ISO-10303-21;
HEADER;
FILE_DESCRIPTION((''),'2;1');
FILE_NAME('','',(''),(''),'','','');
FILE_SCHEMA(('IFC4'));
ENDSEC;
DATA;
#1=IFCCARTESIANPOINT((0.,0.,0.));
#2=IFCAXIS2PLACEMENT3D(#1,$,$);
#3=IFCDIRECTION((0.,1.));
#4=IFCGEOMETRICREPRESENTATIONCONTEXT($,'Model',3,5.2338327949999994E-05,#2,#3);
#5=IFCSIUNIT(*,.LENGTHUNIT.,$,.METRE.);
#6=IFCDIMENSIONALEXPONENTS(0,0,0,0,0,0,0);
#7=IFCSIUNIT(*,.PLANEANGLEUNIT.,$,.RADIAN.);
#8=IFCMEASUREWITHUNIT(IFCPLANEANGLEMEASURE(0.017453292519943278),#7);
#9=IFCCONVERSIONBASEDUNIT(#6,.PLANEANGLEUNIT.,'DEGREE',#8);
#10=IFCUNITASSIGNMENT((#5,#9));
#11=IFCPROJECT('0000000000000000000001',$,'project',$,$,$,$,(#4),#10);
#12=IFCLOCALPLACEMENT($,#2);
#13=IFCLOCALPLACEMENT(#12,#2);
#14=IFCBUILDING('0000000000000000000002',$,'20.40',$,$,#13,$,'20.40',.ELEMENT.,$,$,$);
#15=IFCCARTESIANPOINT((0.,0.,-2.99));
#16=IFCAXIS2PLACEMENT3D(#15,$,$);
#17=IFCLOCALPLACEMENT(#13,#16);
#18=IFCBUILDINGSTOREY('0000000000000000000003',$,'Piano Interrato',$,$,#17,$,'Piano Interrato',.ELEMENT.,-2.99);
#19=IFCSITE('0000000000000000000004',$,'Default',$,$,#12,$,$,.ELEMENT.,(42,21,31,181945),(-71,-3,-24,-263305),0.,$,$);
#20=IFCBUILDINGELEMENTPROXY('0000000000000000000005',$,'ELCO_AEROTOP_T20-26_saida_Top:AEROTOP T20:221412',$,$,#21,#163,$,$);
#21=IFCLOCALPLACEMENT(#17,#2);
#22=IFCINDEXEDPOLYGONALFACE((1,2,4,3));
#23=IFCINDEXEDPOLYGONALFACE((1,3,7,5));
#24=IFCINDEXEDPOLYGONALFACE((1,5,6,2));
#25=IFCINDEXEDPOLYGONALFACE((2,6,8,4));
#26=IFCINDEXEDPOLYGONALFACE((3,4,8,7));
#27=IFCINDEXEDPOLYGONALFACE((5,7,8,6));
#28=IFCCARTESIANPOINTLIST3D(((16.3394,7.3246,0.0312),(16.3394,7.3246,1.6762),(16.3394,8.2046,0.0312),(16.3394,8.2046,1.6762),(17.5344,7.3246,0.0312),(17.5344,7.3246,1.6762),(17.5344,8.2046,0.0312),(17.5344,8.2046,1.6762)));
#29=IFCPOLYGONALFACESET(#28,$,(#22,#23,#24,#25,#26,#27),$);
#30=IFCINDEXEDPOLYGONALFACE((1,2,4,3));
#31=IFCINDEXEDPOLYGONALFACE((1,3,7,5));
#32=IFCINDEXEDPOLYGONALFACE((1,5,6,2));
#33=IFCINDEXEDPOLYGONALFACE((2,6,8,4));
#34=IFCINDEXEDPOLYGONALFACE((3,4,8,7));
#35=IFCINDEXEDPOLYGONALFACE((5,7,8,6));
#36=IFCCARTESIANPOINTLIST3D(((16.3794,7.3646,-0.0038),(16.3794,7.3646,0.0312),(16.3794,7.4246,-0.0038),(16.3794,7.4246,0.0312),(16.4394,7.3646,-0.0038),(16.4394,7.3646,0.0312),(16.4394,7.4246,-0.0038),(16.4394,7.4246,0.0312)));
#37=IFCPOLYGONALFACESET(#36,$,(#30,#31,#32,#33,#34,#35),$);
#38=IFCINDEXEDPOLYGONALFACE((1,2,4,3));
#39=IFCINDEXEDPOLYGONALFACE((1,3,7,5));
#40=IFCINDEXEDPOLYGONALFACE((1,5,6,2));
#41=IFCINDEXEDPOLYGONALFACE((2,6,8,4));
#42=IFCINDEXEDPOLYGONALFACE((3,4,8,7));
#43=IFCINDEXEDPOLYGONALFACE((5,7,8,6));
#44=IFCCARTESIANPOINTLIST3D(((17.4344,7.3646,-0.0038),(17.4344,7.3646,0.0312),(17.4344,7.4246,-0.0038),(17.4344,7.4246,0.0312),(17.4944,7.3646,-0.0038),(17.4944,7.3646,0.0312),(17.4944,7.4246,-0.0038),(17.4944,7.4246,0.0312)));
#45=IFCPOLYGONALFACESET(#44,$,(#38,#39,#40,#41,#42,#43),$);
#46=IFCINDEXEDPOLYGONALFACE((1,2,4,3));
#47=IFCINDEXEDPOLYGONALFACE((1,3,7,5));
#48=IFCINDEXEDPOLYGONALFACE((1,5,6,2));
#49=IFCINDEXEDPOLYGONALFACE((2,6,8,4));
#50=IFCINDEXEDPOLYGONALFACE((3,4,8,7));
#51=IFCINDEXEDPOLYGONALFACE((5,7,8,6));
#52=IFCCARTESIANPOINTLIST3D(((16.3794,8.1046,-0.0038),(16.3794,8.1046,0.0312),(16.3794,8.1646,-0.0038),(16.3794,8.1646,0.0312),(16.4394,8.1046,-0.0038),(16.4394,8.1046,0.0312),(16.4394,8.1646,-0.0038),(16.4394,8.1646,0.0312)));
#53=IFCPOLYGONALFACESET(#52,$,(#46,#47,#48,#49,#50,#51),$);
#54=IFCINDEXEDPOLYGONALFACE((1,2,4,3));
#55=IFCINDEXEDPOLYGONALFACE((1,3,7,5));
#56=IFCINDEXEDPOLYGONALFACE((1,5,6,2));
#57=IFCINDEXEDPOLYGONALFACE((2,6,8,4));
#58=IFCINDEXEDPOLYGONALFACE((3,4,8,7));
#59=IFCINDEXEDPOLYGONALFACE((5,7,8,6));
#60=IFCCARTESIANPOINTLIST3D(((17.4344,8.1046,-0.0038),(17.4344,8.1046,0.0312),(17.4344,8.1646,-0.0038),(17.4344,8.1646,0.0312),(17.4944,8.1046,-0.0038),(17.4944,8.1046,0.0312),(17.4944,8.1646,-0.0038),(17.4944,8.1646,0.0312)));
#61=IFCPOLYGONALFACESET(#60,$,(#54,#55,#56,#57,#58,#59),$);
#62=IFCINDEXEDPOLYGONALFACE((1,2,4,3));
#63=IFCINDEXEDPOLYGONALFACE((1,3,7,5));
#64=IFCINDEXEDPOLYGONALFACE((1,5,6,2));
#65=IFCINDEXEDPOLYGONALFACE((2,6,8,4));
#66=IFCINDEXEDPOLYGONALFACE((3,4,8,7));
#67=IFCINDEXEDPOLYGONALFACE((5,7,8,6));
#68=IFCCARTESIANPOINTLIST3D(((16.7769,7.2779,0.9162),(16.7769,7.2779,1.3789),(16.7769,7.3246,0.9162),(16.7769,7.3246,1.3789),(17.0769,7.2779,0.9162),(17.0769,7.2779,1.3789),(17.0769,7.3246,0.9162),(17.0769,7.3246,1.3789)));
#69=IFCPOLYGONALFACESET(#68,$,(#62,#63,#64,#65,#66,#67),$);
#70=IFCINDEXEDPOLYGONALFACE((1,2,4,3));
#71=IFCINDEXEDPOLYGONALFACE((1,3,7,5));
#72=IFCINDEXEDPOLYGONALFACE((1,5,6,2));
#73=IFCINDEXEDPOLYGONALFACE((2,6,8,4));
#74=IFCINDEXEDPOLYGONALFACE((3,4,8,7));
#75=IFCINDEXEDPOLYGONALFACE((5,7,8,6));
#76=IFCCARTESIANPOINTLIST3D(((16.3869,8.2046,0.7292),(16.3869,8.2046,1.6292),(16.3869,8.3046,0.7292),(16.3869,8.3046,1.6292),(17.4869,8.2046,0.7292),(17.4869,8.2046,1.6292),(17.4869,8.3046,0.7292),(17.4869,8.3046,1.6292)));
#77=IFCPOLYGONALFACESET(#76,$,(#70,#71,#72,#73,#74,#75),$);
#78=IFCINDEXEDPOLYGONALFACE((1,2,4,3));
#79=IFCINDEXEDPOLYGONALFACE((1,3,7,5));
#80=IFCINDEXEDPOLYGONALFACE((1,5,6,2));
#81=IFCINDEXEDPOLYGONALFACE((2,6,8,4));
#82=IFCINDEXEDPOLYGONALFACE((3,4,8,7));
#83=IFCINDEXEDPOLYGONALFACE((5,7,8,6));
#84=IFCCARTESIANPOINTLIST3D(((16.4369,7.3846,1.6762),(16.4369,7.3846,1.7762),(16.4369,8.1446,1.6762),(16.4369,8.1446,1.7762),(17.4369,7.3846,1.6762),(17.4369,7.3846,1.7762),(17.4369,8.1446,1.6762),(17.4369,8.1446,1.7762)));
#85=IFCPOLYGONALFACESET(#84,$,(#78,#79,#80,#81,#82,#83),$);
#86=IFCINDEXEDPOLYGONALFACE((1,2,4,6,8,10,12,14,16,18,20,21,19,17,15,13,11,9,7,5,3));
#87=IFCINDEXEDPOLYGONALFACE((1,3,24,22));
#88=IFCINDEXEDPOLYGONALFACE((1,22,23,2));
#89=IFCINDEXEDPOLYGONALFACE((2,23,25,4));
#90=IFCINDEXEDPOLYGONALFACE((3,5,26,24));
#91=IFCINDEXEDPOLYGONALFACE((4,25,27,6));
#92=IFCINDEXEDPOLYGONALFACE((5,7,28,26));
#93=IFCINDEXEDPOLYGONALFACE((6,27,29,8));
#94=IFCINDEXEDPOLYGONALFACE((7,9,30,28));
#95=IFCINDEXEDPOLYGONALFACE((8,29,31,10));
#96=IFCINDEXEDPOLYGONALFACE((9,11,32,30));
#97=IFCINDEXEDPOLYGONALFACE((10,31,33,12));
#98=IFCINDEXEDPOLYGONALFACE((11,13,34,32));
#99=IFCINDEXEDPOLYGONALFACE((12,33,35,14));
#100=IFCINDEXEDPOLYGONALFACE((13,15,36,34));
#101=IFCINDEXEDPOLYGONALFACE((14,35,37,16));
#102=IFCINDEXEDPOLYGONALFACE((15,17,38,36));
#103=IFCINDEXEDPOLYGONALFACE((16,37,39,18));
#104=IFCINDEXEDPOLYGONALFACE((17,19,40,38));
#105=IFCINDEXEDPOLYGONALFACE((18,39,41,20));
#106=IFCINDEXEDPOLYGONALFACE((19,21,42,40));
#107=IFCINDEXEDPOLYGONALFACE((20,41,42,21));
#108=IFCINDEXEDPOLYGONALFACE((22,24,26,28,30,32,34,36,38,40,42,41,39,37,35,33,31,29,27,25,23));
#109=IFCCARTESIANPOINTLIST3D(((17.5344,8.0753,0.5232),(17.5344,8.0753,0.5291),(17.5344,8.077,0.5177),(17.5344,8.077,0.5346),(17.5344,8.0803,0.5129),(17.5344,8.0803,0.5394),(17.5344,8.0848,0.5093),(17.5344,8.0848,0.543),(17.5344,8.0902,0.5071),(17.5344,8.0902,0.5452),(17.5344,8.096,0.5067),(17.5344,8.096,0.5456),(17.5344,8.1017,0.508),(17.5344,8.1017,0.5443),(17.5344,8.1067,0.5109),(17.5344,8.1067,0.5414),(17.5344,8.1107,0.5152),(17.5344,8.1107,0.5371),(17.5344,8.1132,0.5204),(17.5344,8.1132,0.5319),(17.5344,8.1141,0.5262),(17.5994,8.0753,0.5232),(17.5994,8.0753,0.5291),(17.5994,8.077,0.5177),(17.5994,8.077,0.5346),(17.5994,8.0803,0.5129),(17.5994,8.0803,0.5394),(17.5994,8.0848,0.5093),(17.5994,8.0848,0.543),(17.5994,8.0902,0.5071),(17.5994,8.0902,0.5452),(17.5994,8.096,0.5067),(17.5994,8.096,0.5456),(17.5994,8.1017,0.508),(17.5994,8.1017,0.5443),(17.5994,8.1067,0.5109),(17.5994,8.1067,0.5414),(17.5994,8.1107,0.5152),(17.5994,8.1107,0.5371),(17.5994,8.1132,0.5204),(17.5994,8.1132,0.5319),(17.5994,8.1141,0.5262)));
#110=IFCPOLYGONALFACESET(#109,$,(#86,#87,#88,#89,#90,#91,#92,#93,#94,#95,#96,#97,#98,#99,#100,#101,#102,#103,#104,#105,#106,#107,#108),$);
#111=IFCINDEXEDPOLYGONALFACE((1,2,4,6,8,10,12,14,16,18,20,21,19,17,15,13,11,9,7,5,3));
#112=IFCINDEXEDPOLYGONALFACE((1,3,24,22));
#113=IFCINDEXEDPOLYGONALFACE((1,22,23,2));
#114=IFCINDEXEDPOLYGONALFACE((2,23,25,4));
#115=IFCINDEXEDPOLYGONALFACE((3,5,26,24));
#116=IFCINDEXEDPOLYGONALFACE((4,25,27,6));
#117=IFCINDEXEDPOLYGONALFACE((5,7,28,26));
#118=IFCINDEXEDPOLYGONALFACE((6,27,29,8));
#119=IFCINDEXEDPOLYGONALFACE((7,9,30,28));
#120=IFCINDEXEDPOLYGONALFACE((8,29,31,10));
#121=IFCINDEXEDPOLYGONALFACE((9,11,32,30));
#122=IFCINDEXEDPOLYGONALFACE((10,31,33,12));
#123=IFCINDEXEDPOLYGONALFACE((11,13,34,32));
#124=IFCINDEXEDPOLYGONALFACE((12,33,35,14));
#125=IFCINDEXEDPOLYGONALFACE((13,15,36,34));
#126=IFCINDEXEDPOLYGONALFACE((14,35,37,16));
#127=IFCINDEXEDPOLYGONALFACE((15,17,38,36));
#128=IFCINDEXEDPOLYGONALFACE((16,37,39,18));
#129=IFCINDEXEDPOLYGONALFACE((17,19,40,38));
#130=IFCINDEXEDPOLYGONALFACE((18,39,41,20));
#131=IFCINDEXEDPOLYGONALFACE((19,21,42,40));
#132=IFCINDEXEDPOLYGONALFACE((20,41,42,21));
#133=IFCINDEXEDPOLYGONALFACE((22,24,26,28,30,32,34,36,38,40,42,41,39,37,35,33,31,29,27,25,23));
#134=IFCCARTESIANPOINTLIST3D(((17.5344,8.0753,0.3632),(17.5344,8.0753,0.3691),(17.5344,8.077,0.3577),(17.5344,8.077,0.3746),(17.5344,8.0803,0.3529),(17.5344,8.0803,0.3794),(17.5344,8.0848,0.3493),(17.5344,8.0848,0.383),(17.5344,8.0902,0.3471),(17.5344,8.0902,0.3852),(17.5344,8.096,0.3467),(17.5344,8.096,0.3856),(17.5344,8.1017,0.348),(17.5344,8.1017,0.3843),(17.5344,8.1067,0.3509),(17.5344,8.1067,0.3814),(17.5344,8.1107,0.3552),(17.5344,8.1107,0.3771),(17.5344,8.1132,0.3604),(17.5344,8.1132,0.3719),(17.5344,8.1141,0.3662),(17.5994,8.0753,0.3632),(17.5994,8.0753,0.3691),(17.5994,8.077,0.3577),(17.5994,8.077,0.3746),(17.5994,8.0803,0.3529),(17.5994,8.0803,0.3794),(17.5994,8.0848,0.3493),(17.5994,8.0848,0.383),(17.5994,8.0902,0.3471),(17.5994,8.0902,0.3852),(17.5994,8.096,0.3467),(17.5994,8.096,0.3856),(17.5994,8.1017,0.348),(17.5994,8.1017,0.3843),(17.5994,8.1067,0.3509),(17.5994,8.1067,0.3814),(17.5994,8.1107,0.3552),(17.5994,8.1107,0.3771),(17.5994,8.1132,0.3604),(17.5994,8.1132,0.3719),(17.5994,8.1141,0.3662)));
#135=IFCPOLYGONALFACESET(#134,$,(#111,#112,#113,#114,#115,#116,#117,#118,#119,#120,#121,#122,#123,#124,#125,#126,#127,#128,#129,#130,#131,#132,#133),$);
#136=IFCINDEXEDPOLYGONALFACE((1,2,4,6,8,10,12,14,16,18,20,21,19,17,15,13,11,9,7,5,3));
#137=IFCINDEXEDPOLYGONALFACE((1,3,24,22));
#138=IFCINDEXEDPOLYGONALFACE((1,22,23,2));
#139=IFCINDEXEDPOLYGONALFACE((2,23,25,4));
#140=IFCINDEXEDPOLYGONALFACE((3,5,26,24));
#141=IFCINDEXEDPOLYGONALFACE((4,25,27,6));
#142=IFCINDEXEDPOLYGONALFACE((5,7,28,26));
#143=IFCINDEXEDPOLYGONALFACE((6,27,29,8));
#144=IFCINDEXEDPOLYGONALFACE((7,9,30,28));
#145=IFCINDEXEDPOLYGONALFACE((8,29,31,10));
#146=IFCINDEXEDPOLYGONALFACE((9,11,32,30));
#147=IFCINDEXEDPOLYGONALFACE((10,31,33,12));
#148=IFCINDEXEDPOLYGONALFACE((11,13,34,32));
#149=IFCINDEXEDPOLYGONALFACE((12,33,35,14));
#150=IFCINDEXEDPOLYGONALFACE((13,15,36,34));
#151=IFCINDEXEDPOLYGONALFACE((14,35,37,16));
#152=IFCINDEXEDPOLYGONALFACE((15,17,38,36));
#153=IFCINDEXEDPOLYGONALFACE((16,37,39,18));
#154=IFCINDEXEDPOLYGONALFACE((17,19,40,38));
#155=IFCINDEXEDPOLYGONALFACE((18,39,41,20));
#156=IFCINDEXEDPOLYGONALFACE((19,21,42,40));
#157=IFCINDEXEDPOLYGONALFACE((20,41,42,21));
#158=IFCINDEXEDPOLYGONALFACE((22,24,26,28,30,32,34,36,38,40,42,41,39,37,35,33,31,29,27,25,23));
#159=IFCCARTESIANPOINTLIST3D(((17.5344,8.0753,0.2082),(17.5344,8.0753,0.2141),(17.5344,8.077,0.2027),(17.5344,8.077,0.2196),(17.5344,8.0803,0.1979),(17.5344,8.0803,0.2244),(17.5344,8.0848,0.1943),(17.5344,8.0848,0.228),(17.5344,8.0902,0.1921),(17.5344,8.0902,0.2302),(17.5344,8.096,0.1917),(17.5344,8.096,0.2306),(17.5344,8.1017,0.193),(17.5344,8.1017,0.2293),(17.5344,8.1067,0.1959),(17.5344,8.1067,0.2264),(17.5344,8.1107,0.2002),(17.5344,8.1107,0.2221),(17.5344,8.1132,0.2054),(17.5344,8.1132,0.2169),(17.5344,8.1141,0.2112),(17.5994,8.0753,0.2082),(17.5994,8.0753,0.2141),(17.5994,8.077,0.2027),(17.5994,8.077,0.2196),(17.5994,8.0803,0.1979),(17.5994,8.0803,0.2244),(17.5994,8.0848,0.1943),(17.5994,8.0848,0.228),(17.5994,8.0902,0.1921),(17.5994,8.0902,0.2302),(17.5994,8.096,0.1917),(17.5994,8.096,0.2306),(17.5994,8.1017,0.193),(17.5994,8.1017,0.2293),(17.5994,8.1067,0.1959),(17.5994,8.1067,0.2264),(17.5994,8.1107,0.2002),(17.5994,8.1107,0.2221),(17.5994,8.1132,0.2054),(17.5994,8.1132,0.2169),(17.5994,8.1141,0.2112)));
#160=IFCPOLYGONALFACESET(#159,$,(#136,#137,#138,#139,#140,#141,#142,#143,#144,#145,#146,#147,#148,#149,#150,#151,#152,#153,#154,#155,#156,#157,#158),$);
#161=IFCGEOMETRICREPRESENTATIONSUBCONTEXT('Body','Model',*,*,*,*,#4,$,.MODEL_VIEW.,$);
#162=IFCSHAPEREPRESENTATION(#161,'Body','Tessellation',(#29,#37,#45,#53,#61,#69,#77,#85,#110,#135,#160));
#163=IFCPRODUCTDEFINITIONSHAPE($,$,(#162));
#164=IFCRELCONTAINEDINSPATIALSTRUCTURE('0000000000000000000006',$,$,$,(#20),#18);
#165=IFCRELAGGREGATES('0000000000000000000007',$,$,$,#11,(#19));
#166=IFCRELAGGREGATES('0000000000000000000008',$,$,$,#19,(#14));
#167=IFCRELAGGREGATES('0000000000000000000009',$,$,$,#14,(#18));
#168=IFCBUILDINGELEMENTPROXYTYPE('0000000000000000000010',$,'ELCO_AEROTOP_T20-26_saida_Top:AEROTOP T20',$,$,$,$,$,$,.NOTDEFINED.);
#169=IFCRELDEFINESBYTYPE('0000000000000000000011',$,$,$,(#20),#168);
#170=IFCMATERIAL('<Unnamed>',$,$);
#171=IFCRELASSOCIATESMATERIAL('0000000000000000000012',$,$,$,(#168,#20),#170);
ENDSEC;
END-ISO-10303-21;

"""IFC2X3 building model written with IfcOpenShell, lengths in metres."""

from ifc_helpers import new_model, entity, si_unit, converted_unit, direction, frame, frame_2d, origin, origin_2d_with_axis, place, context, subcontext, project, spatial, rectangle, circle, extrude, source, transform, mapped, material, type_object, type_shapes, element, save


model = new_model("IFC2X3")

# Units and contexts
model_context = context("Model", 3, precision=5.2338327949999994e-05, world=origin(), true_north=direction((0.0, 1.0)))
body_context = subcontext(model_context, "Body", "Model", "MODEL_VIEW")
ifc_project = project(units=[si_unit("LENGTHUNIT", "METRE"), converted_unit("PLANEANGLEUNIT", "DEGREE", entity("IfcPlaneAngleMeasure", 0.017453292519943278), si_unit("PLANEANGLEUNIT", "RADIAN"), dimensions=[0, 0, 0, 0, 0, 0, 0])], contexts=[model_context])

# Site, building, storey
site_placement = place(None, origin())
site = spatial("IfcSite", under=ifc_project, at=site_placement, Name="Default", CompositionType="ELEMENT", RefLatitude=(42, 21, 31, 181945), RefLongitude=(-71, -3, -24, -263305), RefElevation=0.0)
building_placement = place(site_placement, origin())
building = spatial("IfcBuilding", under=site, at=building_placement, Name="20.40", LongName="20.40", CompositionType="ELEMENT")
storey_placement = place(building_placement, frame((0.0, 0.0, -2.99)))
storey = spatial("IfcBuildingStorey", under=building, at=storey_placement, Name="Piano Interrato", LongName="Piano Interrato", CompositionType="ELEMENT", Elevation=-2.99)

# Shared definitions
ifc_material_1 = material(Name="<Unnamed>")

# Building element proxy
building_element_proxy_type_1 = type_object("IfcBuildingElementProxyType", Name="ELCO_AEROTOP_T20-26_saida_Top:AEROTOP T20", PredefinedType="NOTDEFINED", material=ifc_material_1)
shared_shape_1 = source(origin(), body_context, "Body", "SweptSolid", [
    extrude(rectangle(XDim=0.88, YDim=1.195, at=origin_2d_with_axis()), frame((0.5975, 0.44, 0.035), z_axis=(0.0, 0.0, 1.0), x_axis=(0.0, 1.0, 0.0)), (0.0, 0.0, 1.0), 1.645),
    extrude(rectangle(XDim=0.06, YDim=0.06, at=frame_2d((0.0, 0.0), x_axis=(1.0, 0.0))), frame((0.07, 0.07, 0.0), z_axis=(0.0, 0.0, 1.0), x_axis=(0.0, 1.0, 0.0)), (0.0, 0.0, 1.0), 0.035),
    extrude(rectangle(XDim=0.06, YDim=0.06, at=frame_2d((0.0, 0.0), x_axis=(1.0, 0.0))), frame((1.125, 0.07, 0.0), z_axis=(0.0, 0.0, 1.0), x_axis=(0.0, 1.0, 0.0)), (0.0, 0.0, 1.0), 0.035),
    extrude(rectangle(XDim=0.06, YDim=0.06, at=frame_2d((0.0, 0.0), x_axis=(1.0, 0.0))), frame((0.07, 0.81, 0.0), z_axis=(0.0, 0.0, 1.0), x_axis=(0.0, 1.0, 0.0)), (0.0, 0.0, 1.0), 0.035),
    extrude(rectangle(XDim=0.06, YDim=0.06, at=frame_2d((0.0, 0.0), x_axis=(1.0, 0.0))), frame((1.125, 0.81, 0.0), z_axis=(0.0, 0.0, 1.0), x_axis=(0.0, 1.0, 0.0)), (0.0, 0.0, 1.0), 0.035),
    extrude(rectangle(XDim=0.0467, YDim=0.3, at=origin_2d_with_axis()), frame((0.5875, -0.0233, 0.92), z_axis=(0.0, 0.0, 1.0), x_axis=(0.0, -1.0, 0.0)), (0.0, 0.0, 1.0), 0.4627),
    extrude(rectangle(XDim=0.1, YDim=1.1, at=frame_2d((0.0, 0.0), x_axis=(1.0, 0.0))), frame((0.5975, 0.93, 0.733), z_axis=(0.0, 0.0, 1.0), x_axis=(0.0, -1.0, 0.0)), (0.0, 0.0, 1.0), 0.9),
    extrude(rectangle(XDim=0.76, YDim=1.0, at=origin_2d_with_axis()), frame((0.5975, 0.44, 1.68), z_axis=(0.0, 0.0, 1.0), x_axis=(0.0, 1.0, 0.0)), (0.0, 0.0, 1.0), 0.1),
    extrude(circle(Radius=0.0195, at=origin_2d_with_axis()), frame((1.195, 0.77, 0.53), z_axis=(1.0, 0.0, 0.0), x_axis=(0.0, 1.0, 0.0)), (0.0, 0.0, 1.0), 0.065),
    extrude(circle(Radius=0.0195, at=origin_2d_with_axis()), frame((1.195, 0.77, 0.37), z_axis=(1.0, 0.0, 0.0), x_axis=(0.0, 1.0, 0.0)), (0.0, 0.0, 1.0), 0.065),
    extrude(circle(Radius=0.0195, at=origin_2d_with_axis()), frame((1.195, 0.77, 0.215), z_axis=(1.0, 0.0, 0.0), x_axis=(0.0, 1.0, 0.0)), (0.0, 0.0, 1.0), 0.065),
])
type_shapes(building_element_proxy_type_1, [shared_shape_1])
proxy_1_placement = place(storey_placement, frame((16.3394, 7.3246, -0.0038)))
element("IfcBuildingElementProxy", 1, at=proxy_1_placement, inside=storey, type_object=building_element_proxy_type_1, material=ifc_material_1, Name="ELCO_AEROTOP_T20-26_saida_Top:AEROTOP T20:221412", context=body_context, shape_type="MappedRepresentation", body=[
    mapped(shared_shape_1, transform((0.0, 0.0, 0.0), scale=1.0)),
])

save(model, "model.ifc")
